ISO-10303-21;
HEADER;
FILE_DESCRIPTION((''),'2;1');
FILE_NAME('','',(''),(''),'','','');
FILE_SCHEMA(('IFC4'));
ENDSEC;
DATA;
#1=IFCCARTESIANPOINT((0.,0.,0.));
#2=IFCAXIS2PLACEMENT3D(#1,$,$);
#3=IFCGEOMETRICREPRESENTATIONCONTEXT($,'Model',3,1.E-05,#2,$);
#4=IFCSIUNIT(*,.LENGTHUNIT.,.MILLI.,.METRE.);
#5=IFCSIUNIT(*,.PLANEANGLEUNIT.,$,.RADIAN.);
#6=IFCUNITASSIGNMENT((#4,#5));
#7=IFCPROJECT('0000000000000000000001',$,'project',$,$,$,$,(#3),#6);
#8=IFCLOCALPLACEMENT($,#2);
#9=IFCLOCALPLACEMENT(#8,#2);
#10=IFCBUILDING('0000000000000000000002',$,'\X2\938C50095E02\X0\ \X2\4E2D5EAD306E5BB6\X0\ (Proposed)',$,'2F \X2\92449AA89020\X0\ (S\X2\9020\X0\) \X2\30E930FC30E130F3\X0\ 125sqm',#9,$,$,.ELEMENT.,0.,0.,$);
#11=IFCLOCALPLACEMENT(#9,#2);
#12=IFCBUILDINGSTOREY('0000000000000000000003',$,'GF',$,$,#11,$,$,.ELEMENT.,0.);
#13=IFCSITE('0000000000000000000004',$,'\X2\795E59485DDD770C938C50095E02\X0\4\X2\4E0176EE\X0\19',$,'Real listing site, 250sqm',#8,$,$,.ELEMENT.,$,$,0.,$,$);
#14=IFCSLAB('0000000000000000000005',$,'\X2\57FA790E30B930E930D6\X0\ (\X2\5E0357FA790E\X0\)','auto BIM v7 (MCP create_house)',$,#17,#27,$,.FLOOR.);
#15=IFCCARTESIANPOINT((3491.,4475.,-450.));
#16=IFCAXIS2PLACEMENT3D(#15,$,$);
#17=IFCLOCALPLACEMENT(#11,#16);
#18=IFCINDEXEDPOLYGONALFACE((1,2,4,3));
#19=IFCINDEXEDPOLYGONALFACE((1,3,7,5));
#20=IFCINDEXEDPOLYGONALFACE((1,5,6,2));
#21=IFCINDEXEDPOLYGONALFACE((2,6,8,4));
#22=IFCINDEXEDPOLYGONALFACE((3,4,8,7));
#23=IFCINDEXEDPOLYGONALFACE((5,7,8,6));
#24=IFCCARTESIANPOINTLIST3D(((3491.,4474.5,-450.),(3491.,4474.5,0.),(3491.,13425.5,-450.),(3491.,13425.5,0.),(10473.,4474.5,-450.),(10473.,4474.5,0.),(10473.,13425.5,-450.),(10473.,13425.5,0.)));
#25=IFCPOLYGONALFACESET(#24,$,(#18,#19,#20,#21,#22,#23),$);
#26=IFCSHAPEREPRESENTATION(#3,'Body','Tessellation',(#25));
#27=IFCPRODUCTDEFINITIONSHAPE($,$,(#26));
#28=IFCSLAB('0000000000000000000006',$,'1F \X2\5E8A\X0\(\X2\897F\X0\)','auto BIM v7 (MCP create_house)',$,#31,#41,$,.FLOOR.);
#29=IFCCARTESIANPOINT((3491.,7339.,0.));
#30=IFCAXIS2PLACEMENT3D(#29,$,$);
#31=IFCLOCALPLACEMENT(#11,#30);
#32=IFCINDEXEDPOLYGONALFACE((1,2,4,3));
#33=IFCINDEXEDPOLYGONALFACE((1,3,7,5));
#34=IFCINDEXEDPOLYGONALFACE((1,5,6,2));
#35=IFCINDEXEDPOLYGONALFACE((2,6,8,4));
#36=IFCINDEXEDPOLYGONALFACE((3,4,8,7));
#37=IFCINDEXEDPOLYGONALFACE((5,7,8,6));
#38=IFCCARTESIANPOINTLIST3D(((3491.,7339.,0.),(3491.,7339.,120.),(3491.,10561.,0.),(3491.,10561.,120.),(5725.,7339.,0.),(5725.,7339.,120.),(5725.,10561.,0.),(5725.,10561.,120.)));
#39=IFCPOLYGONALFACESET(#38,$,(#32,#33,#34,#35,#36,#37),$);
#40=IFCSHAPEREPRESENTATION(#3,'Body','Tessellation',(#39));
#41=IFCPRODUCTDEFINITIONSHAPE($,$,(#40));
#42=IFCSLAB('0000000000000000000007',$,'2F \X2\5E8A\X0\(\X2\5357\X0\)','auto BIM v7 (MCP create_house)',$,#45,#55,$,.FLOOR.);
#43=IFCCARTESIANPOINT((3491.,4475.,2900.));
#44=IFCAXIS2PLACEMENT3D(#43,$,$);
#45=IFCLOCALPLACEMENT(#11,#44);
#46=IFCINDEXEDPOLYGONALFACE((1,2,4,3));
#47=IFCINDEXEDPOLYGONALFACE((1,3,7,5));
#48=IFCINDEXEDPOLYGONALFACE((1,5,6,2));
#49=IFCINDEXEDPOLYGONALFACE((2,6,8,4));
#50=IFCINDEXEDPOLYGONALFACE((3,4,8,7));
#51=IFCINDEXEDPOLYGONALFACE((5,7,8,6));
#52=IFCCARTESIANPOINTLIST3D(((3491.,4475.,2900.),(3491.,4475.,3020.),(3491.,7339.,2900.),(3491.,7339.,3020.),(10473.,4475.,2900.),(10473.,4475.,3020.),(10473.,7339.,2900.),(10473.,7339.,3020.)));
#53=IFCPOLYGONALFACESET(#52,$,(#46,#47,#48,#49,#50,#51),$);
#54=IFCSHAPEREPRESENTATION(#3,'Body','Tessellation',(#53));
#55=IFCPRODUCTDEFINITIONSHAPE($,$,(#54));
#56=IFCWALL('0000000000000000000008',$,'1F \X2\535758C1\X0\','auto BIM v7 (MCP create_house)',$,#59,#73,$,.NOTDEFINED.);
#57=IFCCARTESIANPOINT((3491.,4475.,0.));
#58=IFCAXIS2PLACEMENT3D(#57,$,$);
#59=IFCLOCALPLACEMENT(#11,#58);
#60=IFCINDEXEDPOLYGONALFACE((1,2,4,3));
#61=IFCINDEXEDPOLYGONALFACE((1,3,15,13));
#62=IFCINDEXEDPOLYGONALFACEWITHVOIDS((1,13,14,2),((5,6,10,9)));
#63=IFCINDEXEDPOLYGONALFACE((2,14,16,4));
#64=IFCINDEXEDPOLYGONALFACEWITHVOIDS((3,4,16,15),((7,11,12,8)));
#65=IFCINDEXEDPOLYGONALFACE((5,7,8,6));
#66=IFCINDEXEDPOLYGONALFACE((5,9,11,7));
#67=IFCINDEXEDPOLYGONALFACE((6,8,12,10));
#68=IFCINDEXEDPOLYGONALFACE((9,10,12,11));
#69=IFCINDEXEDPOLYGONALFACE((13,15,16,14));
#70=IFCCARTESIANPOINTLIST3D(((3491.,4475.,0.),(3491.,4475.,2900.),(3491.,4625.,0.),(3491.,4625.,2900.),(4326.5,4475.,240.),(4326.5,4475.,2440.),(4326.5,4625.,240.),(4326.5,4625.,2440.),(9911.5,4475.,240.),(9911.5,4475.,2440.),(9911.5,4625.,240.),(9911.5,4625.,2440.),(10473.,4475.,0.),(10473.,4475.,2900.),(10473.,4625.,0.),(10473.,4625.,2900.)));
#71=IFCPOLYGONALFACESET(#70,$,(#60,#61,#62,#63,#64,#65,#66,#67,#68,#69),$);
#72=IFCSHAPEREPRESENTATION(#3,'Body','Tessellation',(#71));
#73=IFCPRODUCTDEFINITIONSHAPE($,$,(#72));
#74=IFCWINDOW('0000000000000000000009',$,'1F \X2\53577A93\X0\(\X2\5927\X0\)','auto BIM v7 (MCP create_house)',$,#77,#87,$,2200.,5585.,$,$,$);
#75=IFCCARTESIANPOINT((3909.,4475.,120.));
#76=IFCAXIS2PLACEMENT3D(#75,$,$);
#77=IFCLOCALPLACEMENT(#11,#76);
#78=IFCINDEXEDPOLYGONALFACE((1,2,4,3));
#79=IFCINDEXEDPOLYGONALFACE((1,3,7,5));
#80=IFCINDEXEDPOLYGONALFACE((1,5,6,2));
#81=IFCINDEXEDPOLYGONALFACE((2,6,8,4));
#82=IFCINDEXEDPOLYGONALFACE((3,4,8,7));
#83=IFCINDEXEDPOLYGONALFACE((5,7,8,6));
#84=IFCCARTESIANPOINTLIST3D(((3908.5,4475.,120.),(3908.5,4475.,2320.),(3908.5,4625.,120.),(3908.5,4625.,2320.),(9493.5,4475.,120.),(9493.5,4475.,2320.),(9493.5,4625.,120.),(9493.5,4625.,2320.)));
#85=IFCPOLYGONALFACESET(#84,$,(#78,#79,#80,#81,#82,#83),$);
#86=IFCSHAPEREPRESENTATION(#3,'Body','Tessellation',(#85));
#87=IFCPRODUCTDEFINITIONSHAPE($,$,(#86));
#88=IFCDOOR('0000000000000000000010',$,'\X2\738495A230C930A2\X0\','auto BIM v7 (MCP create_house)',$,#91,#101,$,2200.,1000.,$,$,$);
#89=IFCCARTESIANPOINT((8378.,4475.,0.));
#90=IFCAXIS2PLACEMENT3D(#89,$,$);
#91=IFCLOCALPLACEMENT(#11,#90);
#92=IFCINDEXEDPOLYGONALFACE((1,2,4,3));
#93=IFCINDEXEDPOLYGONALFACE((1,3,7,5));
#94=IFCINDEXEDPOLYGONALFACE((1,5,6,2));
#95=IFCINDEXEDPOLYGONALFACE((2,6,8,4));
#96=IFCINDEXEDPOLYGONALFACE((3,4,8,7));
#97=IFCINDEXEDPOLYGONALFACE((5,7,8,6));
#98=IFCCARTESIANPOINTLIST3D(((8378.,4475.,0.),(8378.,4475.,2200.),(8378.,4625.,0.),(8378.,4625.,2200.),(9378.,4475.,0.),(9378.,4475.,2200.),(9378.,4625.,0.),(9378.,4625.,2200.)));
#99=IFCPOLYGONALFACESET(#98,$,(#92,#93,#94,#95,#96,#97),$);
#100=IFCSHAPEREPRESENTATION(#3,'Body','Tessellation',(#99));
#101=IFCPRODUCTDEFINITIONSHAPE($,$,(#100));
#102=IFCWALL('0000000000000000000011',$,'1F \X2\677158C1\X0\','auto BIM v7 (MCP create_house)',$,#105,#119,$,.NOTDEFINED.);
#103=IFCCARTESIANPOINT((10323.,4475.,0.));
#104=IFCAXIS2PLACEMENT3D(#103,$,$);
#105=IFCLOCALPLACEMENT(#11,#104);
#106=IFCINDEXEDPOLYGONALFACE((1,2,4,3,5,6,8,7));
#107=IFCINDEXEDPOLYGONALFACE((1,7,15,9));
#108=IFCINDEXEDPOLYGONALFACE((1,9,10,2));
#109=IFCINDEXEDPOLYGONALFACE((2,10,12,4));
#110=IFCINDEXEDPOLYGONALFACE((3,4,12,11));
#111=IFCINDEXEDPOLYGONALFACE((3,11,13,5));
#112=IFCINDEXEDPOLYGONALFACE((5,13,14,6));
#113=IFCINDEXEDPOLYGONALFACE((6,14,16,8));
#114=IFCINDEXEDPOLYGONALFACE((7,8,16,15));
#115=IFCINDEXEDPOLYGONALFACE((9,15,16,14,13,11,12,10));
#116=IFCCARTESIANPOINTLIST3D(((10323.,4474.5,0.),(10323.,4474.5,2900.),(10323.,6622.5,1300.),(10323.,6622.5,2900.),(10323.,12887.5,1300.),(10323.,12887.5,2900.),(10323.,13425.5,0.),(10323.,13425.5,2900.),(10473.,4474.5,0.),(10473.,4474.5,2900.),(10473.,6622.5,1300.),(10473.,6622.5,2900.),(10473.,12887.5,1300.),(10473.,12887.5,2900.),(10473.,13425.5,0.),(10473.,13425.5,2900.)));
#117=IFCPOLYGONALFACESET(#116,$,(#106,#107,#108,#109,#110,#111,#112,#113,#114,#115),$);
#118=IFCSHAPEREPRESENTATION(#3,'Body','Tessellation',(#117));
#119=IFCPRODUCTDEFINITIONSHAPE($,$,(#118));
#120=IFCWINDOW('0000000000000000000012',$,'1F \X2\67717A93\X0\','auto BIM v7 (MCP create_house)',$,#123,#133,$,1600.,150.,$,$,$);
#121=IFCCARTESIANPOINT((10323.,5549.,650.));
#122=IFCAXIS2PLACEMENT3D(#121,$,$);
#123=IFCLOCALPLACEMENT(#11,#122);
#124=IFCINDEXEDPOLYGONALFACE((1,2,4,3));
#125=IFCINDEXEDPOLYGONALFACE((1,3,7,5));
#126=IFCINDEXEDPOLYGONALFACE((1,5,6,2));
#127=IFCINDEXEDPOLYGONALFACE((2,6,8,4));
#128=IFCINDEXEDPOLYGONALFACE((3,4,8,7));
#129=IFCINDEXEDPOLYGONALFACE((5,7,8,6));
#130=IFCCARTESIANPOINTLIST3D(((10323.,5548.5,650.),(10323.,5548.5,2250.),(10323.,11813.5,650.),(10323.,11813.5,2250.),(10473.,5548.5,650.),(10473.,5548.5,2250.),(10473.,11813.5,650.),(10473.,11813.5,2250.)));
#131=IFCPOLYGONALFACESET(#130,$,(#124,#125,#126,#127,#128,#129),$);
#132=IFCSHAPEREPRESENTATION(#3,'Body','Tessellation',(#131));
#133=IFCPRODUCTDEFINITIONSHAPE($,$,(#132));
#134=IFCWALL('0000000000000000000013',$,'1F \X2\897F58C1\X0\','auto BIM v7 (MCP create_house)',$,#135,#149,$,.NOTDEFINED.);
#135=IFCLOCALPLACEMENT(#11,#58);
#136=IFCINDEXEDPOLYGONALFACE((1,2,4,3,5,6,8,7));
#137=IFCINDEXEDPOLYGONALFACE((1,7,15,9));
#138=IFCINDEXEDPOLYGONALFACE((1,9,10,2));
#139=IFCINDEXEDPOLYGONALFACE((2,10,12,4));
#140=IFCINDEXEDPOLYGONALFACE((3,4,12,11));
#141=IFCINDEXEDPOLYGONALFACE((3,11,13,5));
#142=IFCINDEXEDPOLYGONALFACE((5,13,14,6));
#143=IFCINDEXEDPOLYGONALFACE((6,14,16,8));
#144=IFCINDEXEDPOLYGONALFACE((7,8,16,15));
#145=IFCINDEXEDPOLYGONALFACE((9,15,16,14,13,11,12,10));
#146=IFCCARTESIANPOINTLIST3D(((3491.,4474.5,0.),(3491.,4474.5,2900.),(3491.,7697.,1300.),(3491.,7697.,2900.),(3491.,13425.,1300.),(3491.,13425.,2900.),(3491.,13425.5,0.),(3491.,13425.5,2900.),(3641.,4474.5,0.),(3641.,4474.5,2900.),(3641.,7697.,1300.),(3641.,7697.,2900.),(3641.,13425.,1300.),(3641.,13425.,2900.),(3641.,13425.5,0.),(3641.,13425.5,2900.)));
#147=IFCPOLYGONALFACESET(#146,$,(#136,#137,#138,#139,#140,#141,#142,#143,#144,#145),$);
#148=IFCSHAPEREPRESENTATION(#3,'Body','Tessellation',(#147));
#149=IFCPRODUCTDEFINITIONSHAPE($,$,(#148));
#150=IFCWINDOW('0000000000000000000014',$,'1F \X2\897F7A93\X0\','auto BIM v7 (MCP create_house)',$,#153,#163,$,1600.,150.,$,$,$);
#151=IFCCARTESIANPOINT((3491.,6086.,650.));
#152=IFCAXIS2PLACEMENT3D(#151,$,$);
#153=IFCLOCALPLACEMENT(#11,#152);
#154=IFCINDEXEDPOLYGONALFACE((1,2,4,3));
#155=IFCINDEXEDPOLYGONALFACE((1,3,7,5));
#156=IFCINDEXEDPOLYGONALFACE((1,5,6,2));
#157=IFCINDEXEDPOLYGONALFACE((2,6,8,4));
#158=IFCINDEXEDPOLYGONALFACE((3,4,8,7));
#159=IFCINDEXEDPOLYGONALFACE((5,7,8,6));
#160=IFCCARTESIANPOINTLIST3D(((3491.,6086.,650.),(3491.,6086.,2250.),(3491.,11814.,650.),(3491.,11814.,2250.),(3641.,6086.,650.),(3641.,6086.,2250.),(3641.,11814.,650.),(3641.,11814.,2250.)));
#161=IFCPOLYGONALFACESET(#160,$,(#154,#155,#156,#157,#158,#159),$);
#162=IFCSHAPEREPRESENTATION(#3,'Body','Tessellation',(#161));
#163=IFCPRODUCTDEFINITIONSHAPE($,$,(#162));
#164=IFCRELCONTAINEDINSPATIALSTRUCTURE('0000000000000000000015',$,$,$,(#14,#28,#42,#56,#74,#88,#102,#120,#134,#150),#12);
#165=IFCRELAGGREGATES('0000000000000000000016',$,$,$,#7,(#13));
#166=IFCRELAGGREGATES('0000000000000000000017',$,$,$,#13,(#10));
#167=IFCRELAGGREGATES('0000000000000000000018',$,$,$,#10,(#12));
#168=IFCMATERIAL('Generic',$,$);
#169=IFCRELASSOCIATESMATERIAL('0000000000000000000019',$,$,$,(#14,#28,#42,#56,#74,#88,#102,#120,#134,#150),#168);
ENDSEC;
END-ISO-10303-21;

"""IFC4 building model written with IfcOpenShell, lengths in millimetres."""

from ifc_helpers import new_model, si_unit, frame, frame_2d, origin, place, context, project, spatial, rectangle, extrude, material, element, fill, save


model = new_model("IFC4")

# Units and contexts
model_context = context("Model", 3, precision=1e-05, world=origin())
ifc_project = project(units=[si_unit("LENGTHUNIT", "METRE", prefix="MILLI"), si_unit("PLANEANGLEUNIT", "RADIAN")], contexts=[model_context])

# Site, building, storey
site_placement = place(None, origin())
site = spatial("IfcSite", under=ifc_project, at=site_placement, Name="神奈川県鎌倉市4丁目19", ObjectType="Real listing site, 250sqm", CompositionType="ELEMENT", RefElevation=0.0)
building_placement = place(site_placement, origin())
building = spatial("IfcBuilding", under=site, at=building_placement, Name="鎌倉市 中庭の家 (Proposed)", ObjectType="2F 鉄骨造 (S造) ラーメン 125sqm", CompositionType="ELEMENT", ElevationOfRefHeight=0.0, ElevationOfTerrain=0.0)
storey_placement = place(building_placement, origin())
storey = spatial("IfcBuildingStorey", under=building, at=storey_placement, Name="GF", CompositionType="ELEMENT", Elevation=0.0)

# Slabs
ifc_material = material(Name="Generic")
slab_1_placement = place(storey_placement, frame((3491.0, 4475.0, -450.0)))
element("IfcSlab", 1, at=slab_1_placement, inside=storey, material=ifc_material, Name="基礎スラブ (布基礎)", Description="auto BIM v7 (MCP create_house)", PredefinedType="FLOOR", context=model_context, shape_type="SweptSolid", body=[
    extrude(rectangle(XDim=6982.0, YDim=8951.0, at=frame_2d((3491.0, 4475.0))), frame((3491.0, 4475.0, -450.0)), (0.0, 0.0, 1.0), 450.0),
])
slab_2_placement = place(storey_placement, frame((3491.0, 7339.0, 0.0)))
element("IfcSlab", 2, at=slab_2_placement, inside=storey, material=ifc_material, Name="1F 床(西)", Description="auto BIM v7 (MCP create_house)", PredefinedType="FLOOR", context=model_context, shape_type="SweptSolid", body=[
    extrude(rectangle(XDim=2234.0, YDim=3222.0, at=frame_2d((1117.0, 1611.0))), frame((3491.0, 7339.0, 0.0)), (0.0, 0.0, 1.0), 120.0),
])
slab_3_placement = place(storey_placement, frame((3491.0, 4475.0, 2900.0)))
element("IfcSlab", 3, at=slab_3_placement, inside=storey, material=ifc_material, Name="2F 床(南)", Description="auto BIM v7 (MCP create_house)", PredefinedType="FLOOR", context=model_context, shape_type="SweptSolid", body=[
    extrude(rectangle(XDim=6982.0, YDim=2864.0, at=frame_2d((3491.0, 1432.0))), frame((3491.0, 4475.0, 2900.0)), (0.0, 0.0, 1.0), 120.0),
])

# Wall, openings, window, door
wall_1_placement = place(storey_placement, frame((3491.0, 4475.0, 0.0)))
wall_1 = element("IfcWall", 4, at=wall_1_placement, inside=storey, material=ifc_material, Name="1F 南壁", Description="auto BIM v7 (MCP create_house)", PredefinedType="NOTDEFINED", context=model_context, shape_type="SweptSolid", body=[
    extrude(rectangle(XDim=6982.0, YDim=150.0, at=frame_2d((3491.0, 75.0))), frame((3491.0, 4475.0, 0.0)), (0.0, 0.0, 1.0), 2900.0),
])
opening_1_placement = place(storey_placement, frame((3909.0, 4475.0, 120.0)))
opening_1 = element("IfcOpeningElement", 5, at=opening_1_placement, cuts=wall_1, PredefinedType="NOTDEFINED", context=model_context, shape_type="SweptSolid", body=[
    extrude(rectangle(XDim=5585.0, YDim=150.0, at=frame_2d((2792.0, 75.0))), frame((3909.0, 4475.0, 120.0)), (0.0, 0.0, 1.0), 2200.0),
])
opening_2_placement = place(storey_placement, frame((8378.0, 4475.0, 0.0)))
opening_2 = element("IfcOpeningElement", 6, at=opening_2_placement, cuts=wall_1, PredefinedType="NOTDEFINED", context=model_context, shape_type="SweptSolid", body=[
    extrude(rectangle(XDim=1000.0, YDim=150.0, at=frame_2d((500.0, 75.0))), frame((8378.0, 4475.0, 0.0)), (0.0, 0.0, 1.0), 2200.0),
])
window_1_placement = place(storey_placement, frame((3909.0, 4475.0, 120.0)))
window_1 = element("IfcWindow", 7, at=window_1_placement, inside=storey, material=ifc_material, Name="1F 南窓(大)", Description="auto BIM v7 (MCP create_house)", OverallHeight=2200.0, OverallWidth=5585.0, context=model_context, shape_type="SweptSolid", body=[
    extrude(rectangle(XDim=5585.0, YDim=150.0, at=frame_2d((2792.0, 75.0))), frame((3909.0, 4475.0, 120.0)), (0.0, 0.0, 1.0), 2200.0),
])
fill(opening_1, window_1)
door_placement = place(storey_placement, frame((8378.0, 4475.0, 0.0)))
door = element("IfcDoor", 8, at=door_placement, inside=storey, material=ifc_material, Name="玄関ドア", Description="auto BIM v7 (MCP create_house)", OverallHeight=2200.0, OverallWidth=1000.0, context=model_context, shape_type="SweptSolid", body=[
    extrude(rectangle(XDim=1000.0, YDim=150.0, at=frame_2d((500.0, 75.0))), frame((8378.0, 4475.0, 0.0)), (0.0, 0.0, 1.0), 2200.0),
])
fill(opening_2, door)

# Walls, openings, windows
wall_2_placement = place(storey_placement, frame((10323.0, 4475.0, 0.0)))
wall_2 = element("IfcWall", 9, at=wall_2_placement, inside=storey, material=ifc_material, Name="1F 東壁", Description="auto BIM v7 (MCP create_house)", PredefinedType="NOTDEFINED", context=model_context, shape_type="SweptSolid", body=[
    extrude(rectangle(XDim=150.0, YDim=8951.0, at=frame_2d((75.0, 4475.0))), frame((10323.0, 4475.0, 0.0)), (0.0, 0.0, 1.0), 2900.0),
])
opening_3_placement = place(storey_placement, frame((10323.0, 5549.0, 650.0)))
opening_3 = element("IfcOpeningElement", 10, at=opening_3_placement, cuts=wall_2, PredefinedType="NOTDEFINED", context=model_context, shape_type="SweptSolid", body=[
    extrude(rectangle(XDim=150.0, YDim=6265.0, at=frame_2d((75.0, 3132.0))), frame((10323.0, 5549.0, 650.0)), (0.0, 0.0, 1.0), 1600.0),
])
window_2_placement = place(storey_placement, frame((10323.0, 5549.0, 650.0)))
window_2 = element("IfcWindow", 11, at=window_2_placement, inside=storey, material=ifc_material, Name="1F 東窓", Description="auto BIM v7 (MCP create_house)", OverallHeight=1600.0, OverallWidth=150.0, context=model_context, shape_type="SweptSolid", body=[
    extrude(rectangle(XDim=150.0, YDim=6265.0, at=frame_2d((75.0, 3132.0))), frame((10323.0, 5549.0, 650.0)), (0.0, 0.0, 1.0), 1600.0),
])
fill(opening_3, window_2)
wall_3_placement = place(storey_placement, frame((3491.0, 4475.0, 0.0)))
wall_3 = element("IfcWall", 12, at=wall_3_placement, inside=storey, material=ifc_material, Name="1F 西壁", Description="auto BIM v7 (MCP create_house)", PredefinedType="NOTDEFINED", context=model_context, shape_type="SweptSolid", body=[
    extrude(rectangle(XDim=150.0, YDim=8951.0, at=frame_2d((75.0, 4475.0))), frame((3491.0, 4475.0, 0.0)), (0.0, 0.0, 1.0), 2900.0),
])
opening_4_placement = place(storey_placement, frame((3491.0, 6086.0, 650.0)))
opening_4 = element("IfcOpeningElement", 13, at=opening_4_placement, cuts=wall_3, PredefinedType="NOTDEFINED", context=model_context, shape_type="SweptSolid", body=[
    extrude(rectangle(XDim=150.0, YDim=5728.0, at=frame_2d((75.0, 2864.0))), frame((3491.0, 6086.0, 650.0)), (0.0, 0.0, 1.0), 1600.0),
])
window_3_placement = place(storey_placement, frame((3491.0, 6086.0, 650.0)))
window_3 = element("IfcWindow", 14, at=window_3_placement, inside=storey, material=ifc_material, Name="1F 西窓", Description="auto BIM v7 (MCP create_house)", OverallHeight=1600.0, OverallWidth=150.0, context=model_context, shape_type="SweptSolid", body=[
    extrude(rectangle(XDim=150.0, YDim=5728.0, at=frame_2d((75.0, 2864.0))), frame((3491.0, 6086.0, 650.0)), (0.0, 0.0, 1.0), 1600.0),
])
fill(opening_4, window_3)

save(model, "model.ifc")
